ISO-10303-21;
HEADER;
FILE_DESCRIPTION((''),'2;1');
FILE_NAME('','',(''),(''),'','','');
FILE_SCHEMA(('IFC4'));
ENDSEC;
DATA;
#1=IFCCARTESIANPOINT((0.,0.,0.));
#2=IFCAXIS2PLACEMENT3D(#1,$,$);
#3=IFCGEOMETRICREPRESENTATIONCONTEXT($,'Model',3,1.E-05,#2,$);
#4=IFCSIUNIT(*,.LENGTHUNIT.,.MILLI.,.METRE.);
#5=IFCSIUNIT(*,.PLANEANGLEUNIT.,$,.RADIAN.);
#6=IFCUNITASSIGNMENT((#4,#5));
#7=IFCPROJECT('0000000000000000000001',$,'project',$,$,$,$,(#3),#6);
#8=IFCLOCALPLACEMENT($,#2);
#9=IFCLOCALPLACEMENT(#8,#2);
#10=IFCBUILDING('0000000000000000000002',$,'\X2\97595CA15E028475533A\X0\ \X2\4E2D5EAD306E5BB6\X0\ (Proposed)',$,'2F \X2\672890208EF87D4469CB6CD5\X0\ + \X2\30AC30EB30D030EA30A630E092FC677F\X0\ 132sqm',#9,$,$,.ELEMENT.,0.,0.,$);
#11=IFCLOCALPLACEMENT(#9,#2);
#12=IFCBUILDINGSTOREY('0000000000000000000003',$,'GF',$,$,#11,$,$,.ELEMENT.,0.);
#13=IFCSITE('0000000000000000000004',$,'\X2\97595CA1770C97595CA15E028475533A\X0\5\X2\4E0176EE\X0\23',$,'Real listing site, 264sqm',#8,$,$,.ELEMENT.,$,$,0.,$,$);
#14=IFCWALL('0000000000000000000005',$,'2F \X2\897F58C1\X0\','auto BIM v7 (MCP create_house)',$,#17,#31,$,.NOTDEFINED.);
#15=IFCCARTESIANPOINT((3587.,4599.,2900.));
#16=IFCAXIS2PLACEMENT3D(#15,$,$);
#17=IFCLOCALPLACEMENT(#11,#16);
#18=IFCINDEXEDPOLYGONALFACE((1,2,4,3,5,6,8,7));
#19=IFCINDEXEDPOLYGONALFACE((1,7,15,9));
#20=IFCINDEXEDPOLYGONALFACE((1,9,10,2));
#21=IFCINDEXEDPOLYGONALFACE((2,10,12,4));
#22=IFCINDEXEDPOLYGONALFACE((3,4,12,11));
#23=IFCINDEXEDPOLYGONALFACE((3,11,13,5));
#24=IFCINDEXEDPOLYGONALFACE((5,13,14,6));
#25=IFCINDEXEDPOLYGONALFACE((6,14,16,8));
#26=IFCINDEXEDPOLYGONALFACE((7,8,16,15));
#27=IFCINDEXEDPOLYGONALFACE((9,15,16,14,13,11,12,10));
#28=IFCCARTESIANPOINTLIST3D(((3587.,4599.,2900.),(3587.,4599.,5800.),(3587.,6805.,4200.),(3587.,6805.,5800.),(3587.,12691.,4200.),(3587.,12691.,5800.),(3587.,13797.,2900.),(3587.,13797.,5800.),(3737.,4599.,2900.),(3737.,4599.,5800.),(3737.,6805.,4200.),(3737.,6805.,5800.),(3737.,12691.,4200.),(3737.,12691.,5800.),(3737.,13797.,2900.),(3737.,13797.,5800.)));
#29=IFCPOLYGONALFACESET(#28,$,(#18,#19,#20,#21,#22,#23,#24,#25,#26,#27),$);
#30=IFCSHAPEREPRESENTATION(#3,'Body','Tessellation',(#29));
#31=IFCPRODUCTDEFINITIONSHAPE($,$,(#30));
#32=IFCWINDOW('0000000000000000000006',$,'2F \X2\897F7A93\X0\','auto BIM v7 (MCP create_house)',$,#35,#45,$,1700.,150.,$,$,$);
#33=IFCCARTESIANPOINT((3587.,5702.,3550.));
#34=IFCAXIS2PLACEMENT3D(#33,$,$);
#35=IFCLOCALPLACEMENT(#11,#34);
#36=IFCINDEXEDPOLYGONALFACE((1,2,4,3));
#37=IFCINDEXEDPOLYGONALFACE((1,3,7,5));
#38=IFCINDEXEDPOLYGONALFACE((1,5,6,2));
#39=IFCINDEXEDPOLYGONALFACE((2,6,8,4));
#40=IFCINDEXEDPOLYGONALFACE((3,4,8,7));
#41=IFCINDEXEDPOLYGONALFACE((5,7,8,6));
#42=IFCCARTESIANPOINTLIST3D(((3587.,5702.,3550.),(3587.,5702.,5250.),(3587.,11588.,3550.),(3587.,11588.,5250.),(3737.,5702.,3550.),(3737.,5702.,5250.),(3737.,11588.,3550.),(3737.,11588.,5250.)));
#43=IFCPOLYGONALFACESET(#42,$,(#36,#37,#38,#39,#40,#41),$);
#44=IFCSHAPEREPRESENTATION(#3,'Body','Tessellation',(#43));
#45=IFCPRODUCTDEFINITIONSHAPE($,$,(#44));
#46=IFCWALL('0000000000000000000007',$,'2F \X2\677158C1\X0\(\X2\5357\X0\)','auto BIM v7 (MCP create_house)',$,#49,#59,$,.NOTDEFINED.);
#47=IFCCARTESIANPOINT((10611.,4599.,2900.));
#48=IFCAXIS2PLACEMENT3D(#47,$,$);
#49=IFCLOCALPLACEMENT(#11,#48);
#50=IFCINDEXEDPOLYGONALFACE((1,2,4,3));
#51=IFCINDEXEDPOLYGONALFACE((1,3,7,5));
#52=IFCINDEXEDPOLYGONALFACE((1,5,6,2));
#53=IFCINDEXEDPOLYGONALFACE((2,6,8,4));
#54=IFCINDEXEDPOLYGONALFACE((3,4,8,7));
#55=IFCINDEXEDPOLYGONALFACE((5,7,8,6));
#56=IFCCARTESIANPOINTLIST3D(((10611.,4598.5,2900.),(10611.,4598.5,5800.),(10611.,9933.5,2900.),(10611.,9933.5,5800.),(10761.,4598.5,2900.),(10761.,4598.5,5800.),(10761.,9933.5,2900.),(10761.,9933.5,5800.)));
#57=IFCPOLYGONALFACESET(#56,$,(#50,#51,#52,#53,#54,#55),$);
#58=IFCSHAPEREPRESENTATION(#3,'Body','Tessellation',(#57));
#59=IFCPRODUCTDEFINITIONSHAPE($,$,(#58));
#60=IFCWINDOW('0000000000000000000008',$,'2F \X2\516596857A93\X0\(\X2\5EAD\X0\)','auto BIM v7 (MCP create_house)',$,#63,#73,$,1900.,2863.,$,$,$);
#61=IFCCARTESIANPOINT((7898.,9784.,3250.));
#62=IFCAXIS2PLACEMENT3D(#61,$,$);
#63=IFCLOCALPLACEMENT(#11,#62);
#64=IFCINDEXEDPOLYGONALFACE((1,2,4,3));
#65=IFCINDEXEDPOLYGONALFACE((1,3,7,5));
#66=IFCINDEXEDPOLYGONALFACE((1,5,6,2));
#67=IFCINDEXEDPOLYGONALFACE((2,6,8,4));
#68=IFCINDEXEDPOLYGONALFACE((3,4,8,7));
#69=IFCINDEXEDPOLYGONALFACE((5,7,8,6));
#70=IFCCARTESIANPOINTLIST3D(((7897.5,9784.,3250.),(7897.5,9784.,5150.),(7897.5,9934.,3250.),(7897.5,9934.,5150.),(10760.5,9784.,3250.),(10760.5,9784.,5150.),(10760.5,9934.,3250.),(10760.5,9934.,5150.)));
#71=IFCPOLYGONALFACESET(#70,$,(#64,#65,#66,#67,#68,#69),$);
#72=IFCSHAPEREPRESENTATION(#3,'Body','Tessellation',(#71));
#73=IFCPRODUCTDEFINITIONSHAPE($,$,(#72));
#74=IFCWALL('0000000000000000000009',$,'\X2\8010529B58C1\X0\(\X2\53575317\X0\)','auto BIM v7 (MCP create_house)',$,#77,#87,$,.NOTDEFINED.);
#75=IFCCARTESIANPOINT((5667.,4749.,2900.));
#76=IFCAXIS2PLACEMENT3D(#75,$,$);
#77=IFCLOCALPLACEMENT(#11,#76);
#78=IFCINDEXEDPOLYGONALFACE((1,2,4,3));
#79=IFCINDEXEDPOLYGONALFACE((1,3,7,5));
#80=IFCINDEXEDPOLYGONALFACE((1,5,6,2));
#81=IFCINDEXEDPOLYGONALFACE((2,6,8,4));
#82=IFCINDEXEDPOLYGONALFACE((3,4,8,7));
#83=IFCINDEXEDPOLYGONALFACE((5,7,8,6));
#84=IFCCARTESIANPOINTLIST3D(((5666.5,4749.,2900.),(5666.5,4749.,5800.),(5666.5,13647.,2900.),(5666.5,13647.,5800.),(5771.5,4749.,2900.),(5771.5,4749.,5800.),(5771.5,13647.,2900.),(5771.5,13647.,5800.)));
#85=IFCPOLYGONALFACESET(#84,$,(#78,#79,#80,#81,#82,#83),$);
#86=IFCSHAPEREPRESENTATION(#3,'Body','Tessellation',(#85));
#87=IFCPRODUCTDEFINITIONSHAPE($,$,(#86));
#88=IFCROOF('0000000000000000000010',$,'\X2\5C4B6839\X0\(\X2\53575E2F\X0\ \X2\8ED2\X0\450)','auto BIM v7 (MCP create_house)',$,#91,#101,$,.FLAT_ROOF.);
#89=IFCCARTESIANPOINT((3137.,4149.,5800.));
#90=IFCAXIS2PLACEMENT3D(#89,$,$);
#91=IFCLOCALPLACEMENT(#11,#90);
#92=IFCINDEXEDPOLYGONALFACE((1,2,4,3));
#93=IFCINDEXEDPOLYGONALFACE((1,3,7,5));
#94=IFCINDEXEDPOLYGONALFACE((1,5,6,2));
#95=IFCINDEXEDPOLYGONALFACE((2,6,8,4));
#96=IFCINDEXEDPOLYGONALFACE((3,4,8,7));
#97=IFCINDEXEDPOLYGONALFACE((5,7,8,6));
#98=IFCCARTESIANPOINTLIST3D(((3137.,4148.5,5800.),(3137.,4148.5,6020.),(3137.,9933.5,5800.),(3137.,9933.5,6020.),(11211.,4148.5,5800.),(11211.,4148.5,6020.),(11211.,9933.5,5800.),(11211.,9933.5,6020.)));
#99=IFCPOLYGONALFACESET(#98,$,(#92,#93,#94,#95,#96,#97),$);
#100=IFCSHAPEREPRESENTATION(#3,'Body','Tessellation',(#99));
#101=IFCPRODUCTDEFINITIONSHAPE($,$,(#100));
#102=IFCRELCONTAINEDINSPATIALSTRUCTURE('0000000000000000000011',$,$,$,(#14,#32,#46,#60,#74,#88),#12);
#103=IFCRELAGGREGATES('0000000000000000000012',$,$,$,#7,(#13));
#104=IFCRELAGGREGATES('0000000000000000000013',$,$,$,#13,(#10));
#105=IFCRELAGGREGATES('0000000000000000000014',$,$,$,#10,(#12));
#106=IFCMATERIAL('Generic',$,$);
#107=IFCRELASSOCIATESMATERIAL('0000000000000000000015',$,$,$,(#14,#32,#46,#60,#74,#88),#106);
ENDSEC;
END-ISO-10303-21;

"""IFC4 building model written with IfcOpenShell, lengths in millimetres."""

from ifc_helpers import new_model, si_unit, frame, frame_2d, origin, place, context, project, spatial, rectangle, extrude, material, element, fill, save


model = new_model("IFC4")

# Units and contexts
model_context = context("Model", 3, precision=1e-05, world=origin())
ifc_project = project(units=[si_unit("LENGTHUNIT", "METRE", prefix="MILLI"), si_unit("PLANEANGLEUNIT", "RADIAN")], contexts=[model_context])

# Site, building, storey
site_placement = place(None, origin())
site = spatial("IfcSite", under=ifc_project, at=site_placement, Name="静岡県静岡市葵区5丁目23", ObjectType="Real listing site, 264sqm", CompositionType="ELEMENT", RefElevation=0.0)
building_placement = place(site_placement, origin())
building = spatial("IfcBuilding", under=site, at=building_placement, Name="静岡市葵区 中庭の家 (Proposed)", ObjectType="2F 木造軸組構法 + ガルバリウム鋼板 132sqm", CompositionType="ELEMENT", ElevationOfRefHeight=0.0, ElevationOfTerrain=0.0)
storey_placement = place(building_placement, origin())
storey = spatial("IfcBuildingStorey", under=building, at=storey_placement, Name="GF", CompositionType="ELEMENT", Elevation=0.0)

# Shared definitions
ifc_material = material(Name="Generic")

# Walls, openings, windows
wall_1_placement = place(storey_placement, frame((3587.0, 4599.0, 2900.0)))
wall_1 = element("IfcWall", 1, at=wall_1_placement, inside=storey, material=ifc_material, Name="2F 西壁", Description="auto BIM v7 (MCP create_house)", PredefinedType="NOTDEFINED", context=model_context, shape_type="SweptSolid", body=[
    extrude(rectangle(XDim=150.0, YDim=9198.0, at=frame_2d((75.0, 4599.0))), frame((3587.0, 4599.0, 2900.0)), (0.0, 0.0, 1.0), 2900.0),
])
opening_1_placement = place(storey_placement, frame((3587.0, 5702.0, 3550.0)))
opening_1 = element("IfcOpeningElement", 2, at=opening_1_placement, cuts=wall_1, PredefinedType="NOTDEFINED", context=model_context, shape_type="SweptSolid", body=[
    extrude(rectangle(XDim=150.0, YDim=5886.0, at=frame_2d((75.0, 2943.0))), frame((3587.0, 5702.0, 3550.0)), (0.0, 0.0, 1.0), 1700.0),
])
window_1_placement = place(storey_placement, frame((3587.0, 5702.0, 3550.0)))
window_1 = element("IfcWindow", 3, at=window_1_placement, inside=storey, material=ifc_material, Name="2F 西窓", Description="auto BIM v7 (MCP create_house)", OverallHeight=1700.0, OverallWidth=150.0, context=model_context, shape_type="SweptSolid", body=[
    extrude(rectangle(XDim=150.0, YDim=5886.0, at=frame_2d((75.0, 2943.0))), frame((3587.0, 5702.0, 3550.0)), (0.0, 0.0, 1.0), 1700.0),
])
fill(opening_1, window_1)
wall_2_placement = place(storey_placement, frame((10611.0, 4599.0, 2900.0)))
wall_2 = element("IfcWall", 4, at=wall_2_placement, inside=storey, material=ifc_material, Name="2F 東壁(南)", Description="auto BIM v7 (MCP create_house)", PredefinedType="NOTDEFINED", context=model_context, shape_type="SweptSolid", body=[
    extrude(rectangle(XDim=150.0, YDim=5335.0, at=frame_2d((75.0, 2667.0))), frame((10611.0, 4599.0, 2900.0)), (0.0, 0.0, 1.0), 2900.0),
])
opening_2_placement = place(storey_placement, frame((7898.0, 9784.0, 3250.0)))
opening_2 = element("IfcOpeningElement", 5, at=opening_2_placement, cuts=wall_2, PredefinedType="NOTDEFINED", context=model_context, shape_type="SweptSolid", body=[
    extrude(rectangle(XDim=2863.0, YDim=150.0, at=frame_2d((1431.0, 75.0))), frame((7898.0, 9784.0, 3250.0)), (0.0, 0.0, 1.0), 1900.0),
])
window_2_placement = place(storey_placement, frame((7898.0, 9784.0, 3250.0)))
window_2 = element("IfcWindow", 6, at=window_2_placement, inside=storey, material=ifc_material, Name="2F 入隅窓(庭)", Description="auto BIM v7 (MCP create_house)", OverallHeight=1900.0, OverallWidth=2863.0, context=model_context, shape_type="SweptSolid", body=[
    extrude(rectangle(XDim=2863.0, YDim=150.0, at=frame_2d((1431.0, 75.0))), frame((7898.0, 9784.0, 3250.0)), (0.0, 0.0, 1.0), 1900.0),
])
fill(opening_2, window_2)

# Wall
wall_3_placement = place(storey_placement, frame((5667.0, 4749.0, 2900.0)))
element("IfcWall", 7, at=wall_3_placement, inside=storey, material=ifc_material, Name="耐力壁(南北)", Description="auto BIM v7 (MCP create_house)", PredefinedType="NOTDEFINED", context=model_context, shape_type="SweptSolid", body=[
    extrude(rectangle(XDim=105.0, YDim=8898.0, at=frame_2d((52.0, 4449.0))), frame((5667.0, 4749.0, 2900.0)), (0.0, 0.0, 1.0), 2900.0),
])

# Roof
for number, where, name in (
    (8, (3137.0, 4149.0, 5800.0), "屋根(南帯 軒450)"),
):
    element("IfcRoof", number, at=place(storey_placement, frame(where)), inside=storey, material=ifc_material, Name=name, Description="auto BIM v7 (MCP create_house)", PredefinedType="FLAT_ROOF", context=model_context, shape_type="SweptSolid", body=[
        extrude(rectangle(XDim=8074.0, YDim=5785.0, at=frame_2d((4037.0, 2892.0))), frame((3137.0, 4149.0, 5800.0)), (0.0, 0.0, 1.0), 220.0),
    ])

save(model, "model.ifc")
